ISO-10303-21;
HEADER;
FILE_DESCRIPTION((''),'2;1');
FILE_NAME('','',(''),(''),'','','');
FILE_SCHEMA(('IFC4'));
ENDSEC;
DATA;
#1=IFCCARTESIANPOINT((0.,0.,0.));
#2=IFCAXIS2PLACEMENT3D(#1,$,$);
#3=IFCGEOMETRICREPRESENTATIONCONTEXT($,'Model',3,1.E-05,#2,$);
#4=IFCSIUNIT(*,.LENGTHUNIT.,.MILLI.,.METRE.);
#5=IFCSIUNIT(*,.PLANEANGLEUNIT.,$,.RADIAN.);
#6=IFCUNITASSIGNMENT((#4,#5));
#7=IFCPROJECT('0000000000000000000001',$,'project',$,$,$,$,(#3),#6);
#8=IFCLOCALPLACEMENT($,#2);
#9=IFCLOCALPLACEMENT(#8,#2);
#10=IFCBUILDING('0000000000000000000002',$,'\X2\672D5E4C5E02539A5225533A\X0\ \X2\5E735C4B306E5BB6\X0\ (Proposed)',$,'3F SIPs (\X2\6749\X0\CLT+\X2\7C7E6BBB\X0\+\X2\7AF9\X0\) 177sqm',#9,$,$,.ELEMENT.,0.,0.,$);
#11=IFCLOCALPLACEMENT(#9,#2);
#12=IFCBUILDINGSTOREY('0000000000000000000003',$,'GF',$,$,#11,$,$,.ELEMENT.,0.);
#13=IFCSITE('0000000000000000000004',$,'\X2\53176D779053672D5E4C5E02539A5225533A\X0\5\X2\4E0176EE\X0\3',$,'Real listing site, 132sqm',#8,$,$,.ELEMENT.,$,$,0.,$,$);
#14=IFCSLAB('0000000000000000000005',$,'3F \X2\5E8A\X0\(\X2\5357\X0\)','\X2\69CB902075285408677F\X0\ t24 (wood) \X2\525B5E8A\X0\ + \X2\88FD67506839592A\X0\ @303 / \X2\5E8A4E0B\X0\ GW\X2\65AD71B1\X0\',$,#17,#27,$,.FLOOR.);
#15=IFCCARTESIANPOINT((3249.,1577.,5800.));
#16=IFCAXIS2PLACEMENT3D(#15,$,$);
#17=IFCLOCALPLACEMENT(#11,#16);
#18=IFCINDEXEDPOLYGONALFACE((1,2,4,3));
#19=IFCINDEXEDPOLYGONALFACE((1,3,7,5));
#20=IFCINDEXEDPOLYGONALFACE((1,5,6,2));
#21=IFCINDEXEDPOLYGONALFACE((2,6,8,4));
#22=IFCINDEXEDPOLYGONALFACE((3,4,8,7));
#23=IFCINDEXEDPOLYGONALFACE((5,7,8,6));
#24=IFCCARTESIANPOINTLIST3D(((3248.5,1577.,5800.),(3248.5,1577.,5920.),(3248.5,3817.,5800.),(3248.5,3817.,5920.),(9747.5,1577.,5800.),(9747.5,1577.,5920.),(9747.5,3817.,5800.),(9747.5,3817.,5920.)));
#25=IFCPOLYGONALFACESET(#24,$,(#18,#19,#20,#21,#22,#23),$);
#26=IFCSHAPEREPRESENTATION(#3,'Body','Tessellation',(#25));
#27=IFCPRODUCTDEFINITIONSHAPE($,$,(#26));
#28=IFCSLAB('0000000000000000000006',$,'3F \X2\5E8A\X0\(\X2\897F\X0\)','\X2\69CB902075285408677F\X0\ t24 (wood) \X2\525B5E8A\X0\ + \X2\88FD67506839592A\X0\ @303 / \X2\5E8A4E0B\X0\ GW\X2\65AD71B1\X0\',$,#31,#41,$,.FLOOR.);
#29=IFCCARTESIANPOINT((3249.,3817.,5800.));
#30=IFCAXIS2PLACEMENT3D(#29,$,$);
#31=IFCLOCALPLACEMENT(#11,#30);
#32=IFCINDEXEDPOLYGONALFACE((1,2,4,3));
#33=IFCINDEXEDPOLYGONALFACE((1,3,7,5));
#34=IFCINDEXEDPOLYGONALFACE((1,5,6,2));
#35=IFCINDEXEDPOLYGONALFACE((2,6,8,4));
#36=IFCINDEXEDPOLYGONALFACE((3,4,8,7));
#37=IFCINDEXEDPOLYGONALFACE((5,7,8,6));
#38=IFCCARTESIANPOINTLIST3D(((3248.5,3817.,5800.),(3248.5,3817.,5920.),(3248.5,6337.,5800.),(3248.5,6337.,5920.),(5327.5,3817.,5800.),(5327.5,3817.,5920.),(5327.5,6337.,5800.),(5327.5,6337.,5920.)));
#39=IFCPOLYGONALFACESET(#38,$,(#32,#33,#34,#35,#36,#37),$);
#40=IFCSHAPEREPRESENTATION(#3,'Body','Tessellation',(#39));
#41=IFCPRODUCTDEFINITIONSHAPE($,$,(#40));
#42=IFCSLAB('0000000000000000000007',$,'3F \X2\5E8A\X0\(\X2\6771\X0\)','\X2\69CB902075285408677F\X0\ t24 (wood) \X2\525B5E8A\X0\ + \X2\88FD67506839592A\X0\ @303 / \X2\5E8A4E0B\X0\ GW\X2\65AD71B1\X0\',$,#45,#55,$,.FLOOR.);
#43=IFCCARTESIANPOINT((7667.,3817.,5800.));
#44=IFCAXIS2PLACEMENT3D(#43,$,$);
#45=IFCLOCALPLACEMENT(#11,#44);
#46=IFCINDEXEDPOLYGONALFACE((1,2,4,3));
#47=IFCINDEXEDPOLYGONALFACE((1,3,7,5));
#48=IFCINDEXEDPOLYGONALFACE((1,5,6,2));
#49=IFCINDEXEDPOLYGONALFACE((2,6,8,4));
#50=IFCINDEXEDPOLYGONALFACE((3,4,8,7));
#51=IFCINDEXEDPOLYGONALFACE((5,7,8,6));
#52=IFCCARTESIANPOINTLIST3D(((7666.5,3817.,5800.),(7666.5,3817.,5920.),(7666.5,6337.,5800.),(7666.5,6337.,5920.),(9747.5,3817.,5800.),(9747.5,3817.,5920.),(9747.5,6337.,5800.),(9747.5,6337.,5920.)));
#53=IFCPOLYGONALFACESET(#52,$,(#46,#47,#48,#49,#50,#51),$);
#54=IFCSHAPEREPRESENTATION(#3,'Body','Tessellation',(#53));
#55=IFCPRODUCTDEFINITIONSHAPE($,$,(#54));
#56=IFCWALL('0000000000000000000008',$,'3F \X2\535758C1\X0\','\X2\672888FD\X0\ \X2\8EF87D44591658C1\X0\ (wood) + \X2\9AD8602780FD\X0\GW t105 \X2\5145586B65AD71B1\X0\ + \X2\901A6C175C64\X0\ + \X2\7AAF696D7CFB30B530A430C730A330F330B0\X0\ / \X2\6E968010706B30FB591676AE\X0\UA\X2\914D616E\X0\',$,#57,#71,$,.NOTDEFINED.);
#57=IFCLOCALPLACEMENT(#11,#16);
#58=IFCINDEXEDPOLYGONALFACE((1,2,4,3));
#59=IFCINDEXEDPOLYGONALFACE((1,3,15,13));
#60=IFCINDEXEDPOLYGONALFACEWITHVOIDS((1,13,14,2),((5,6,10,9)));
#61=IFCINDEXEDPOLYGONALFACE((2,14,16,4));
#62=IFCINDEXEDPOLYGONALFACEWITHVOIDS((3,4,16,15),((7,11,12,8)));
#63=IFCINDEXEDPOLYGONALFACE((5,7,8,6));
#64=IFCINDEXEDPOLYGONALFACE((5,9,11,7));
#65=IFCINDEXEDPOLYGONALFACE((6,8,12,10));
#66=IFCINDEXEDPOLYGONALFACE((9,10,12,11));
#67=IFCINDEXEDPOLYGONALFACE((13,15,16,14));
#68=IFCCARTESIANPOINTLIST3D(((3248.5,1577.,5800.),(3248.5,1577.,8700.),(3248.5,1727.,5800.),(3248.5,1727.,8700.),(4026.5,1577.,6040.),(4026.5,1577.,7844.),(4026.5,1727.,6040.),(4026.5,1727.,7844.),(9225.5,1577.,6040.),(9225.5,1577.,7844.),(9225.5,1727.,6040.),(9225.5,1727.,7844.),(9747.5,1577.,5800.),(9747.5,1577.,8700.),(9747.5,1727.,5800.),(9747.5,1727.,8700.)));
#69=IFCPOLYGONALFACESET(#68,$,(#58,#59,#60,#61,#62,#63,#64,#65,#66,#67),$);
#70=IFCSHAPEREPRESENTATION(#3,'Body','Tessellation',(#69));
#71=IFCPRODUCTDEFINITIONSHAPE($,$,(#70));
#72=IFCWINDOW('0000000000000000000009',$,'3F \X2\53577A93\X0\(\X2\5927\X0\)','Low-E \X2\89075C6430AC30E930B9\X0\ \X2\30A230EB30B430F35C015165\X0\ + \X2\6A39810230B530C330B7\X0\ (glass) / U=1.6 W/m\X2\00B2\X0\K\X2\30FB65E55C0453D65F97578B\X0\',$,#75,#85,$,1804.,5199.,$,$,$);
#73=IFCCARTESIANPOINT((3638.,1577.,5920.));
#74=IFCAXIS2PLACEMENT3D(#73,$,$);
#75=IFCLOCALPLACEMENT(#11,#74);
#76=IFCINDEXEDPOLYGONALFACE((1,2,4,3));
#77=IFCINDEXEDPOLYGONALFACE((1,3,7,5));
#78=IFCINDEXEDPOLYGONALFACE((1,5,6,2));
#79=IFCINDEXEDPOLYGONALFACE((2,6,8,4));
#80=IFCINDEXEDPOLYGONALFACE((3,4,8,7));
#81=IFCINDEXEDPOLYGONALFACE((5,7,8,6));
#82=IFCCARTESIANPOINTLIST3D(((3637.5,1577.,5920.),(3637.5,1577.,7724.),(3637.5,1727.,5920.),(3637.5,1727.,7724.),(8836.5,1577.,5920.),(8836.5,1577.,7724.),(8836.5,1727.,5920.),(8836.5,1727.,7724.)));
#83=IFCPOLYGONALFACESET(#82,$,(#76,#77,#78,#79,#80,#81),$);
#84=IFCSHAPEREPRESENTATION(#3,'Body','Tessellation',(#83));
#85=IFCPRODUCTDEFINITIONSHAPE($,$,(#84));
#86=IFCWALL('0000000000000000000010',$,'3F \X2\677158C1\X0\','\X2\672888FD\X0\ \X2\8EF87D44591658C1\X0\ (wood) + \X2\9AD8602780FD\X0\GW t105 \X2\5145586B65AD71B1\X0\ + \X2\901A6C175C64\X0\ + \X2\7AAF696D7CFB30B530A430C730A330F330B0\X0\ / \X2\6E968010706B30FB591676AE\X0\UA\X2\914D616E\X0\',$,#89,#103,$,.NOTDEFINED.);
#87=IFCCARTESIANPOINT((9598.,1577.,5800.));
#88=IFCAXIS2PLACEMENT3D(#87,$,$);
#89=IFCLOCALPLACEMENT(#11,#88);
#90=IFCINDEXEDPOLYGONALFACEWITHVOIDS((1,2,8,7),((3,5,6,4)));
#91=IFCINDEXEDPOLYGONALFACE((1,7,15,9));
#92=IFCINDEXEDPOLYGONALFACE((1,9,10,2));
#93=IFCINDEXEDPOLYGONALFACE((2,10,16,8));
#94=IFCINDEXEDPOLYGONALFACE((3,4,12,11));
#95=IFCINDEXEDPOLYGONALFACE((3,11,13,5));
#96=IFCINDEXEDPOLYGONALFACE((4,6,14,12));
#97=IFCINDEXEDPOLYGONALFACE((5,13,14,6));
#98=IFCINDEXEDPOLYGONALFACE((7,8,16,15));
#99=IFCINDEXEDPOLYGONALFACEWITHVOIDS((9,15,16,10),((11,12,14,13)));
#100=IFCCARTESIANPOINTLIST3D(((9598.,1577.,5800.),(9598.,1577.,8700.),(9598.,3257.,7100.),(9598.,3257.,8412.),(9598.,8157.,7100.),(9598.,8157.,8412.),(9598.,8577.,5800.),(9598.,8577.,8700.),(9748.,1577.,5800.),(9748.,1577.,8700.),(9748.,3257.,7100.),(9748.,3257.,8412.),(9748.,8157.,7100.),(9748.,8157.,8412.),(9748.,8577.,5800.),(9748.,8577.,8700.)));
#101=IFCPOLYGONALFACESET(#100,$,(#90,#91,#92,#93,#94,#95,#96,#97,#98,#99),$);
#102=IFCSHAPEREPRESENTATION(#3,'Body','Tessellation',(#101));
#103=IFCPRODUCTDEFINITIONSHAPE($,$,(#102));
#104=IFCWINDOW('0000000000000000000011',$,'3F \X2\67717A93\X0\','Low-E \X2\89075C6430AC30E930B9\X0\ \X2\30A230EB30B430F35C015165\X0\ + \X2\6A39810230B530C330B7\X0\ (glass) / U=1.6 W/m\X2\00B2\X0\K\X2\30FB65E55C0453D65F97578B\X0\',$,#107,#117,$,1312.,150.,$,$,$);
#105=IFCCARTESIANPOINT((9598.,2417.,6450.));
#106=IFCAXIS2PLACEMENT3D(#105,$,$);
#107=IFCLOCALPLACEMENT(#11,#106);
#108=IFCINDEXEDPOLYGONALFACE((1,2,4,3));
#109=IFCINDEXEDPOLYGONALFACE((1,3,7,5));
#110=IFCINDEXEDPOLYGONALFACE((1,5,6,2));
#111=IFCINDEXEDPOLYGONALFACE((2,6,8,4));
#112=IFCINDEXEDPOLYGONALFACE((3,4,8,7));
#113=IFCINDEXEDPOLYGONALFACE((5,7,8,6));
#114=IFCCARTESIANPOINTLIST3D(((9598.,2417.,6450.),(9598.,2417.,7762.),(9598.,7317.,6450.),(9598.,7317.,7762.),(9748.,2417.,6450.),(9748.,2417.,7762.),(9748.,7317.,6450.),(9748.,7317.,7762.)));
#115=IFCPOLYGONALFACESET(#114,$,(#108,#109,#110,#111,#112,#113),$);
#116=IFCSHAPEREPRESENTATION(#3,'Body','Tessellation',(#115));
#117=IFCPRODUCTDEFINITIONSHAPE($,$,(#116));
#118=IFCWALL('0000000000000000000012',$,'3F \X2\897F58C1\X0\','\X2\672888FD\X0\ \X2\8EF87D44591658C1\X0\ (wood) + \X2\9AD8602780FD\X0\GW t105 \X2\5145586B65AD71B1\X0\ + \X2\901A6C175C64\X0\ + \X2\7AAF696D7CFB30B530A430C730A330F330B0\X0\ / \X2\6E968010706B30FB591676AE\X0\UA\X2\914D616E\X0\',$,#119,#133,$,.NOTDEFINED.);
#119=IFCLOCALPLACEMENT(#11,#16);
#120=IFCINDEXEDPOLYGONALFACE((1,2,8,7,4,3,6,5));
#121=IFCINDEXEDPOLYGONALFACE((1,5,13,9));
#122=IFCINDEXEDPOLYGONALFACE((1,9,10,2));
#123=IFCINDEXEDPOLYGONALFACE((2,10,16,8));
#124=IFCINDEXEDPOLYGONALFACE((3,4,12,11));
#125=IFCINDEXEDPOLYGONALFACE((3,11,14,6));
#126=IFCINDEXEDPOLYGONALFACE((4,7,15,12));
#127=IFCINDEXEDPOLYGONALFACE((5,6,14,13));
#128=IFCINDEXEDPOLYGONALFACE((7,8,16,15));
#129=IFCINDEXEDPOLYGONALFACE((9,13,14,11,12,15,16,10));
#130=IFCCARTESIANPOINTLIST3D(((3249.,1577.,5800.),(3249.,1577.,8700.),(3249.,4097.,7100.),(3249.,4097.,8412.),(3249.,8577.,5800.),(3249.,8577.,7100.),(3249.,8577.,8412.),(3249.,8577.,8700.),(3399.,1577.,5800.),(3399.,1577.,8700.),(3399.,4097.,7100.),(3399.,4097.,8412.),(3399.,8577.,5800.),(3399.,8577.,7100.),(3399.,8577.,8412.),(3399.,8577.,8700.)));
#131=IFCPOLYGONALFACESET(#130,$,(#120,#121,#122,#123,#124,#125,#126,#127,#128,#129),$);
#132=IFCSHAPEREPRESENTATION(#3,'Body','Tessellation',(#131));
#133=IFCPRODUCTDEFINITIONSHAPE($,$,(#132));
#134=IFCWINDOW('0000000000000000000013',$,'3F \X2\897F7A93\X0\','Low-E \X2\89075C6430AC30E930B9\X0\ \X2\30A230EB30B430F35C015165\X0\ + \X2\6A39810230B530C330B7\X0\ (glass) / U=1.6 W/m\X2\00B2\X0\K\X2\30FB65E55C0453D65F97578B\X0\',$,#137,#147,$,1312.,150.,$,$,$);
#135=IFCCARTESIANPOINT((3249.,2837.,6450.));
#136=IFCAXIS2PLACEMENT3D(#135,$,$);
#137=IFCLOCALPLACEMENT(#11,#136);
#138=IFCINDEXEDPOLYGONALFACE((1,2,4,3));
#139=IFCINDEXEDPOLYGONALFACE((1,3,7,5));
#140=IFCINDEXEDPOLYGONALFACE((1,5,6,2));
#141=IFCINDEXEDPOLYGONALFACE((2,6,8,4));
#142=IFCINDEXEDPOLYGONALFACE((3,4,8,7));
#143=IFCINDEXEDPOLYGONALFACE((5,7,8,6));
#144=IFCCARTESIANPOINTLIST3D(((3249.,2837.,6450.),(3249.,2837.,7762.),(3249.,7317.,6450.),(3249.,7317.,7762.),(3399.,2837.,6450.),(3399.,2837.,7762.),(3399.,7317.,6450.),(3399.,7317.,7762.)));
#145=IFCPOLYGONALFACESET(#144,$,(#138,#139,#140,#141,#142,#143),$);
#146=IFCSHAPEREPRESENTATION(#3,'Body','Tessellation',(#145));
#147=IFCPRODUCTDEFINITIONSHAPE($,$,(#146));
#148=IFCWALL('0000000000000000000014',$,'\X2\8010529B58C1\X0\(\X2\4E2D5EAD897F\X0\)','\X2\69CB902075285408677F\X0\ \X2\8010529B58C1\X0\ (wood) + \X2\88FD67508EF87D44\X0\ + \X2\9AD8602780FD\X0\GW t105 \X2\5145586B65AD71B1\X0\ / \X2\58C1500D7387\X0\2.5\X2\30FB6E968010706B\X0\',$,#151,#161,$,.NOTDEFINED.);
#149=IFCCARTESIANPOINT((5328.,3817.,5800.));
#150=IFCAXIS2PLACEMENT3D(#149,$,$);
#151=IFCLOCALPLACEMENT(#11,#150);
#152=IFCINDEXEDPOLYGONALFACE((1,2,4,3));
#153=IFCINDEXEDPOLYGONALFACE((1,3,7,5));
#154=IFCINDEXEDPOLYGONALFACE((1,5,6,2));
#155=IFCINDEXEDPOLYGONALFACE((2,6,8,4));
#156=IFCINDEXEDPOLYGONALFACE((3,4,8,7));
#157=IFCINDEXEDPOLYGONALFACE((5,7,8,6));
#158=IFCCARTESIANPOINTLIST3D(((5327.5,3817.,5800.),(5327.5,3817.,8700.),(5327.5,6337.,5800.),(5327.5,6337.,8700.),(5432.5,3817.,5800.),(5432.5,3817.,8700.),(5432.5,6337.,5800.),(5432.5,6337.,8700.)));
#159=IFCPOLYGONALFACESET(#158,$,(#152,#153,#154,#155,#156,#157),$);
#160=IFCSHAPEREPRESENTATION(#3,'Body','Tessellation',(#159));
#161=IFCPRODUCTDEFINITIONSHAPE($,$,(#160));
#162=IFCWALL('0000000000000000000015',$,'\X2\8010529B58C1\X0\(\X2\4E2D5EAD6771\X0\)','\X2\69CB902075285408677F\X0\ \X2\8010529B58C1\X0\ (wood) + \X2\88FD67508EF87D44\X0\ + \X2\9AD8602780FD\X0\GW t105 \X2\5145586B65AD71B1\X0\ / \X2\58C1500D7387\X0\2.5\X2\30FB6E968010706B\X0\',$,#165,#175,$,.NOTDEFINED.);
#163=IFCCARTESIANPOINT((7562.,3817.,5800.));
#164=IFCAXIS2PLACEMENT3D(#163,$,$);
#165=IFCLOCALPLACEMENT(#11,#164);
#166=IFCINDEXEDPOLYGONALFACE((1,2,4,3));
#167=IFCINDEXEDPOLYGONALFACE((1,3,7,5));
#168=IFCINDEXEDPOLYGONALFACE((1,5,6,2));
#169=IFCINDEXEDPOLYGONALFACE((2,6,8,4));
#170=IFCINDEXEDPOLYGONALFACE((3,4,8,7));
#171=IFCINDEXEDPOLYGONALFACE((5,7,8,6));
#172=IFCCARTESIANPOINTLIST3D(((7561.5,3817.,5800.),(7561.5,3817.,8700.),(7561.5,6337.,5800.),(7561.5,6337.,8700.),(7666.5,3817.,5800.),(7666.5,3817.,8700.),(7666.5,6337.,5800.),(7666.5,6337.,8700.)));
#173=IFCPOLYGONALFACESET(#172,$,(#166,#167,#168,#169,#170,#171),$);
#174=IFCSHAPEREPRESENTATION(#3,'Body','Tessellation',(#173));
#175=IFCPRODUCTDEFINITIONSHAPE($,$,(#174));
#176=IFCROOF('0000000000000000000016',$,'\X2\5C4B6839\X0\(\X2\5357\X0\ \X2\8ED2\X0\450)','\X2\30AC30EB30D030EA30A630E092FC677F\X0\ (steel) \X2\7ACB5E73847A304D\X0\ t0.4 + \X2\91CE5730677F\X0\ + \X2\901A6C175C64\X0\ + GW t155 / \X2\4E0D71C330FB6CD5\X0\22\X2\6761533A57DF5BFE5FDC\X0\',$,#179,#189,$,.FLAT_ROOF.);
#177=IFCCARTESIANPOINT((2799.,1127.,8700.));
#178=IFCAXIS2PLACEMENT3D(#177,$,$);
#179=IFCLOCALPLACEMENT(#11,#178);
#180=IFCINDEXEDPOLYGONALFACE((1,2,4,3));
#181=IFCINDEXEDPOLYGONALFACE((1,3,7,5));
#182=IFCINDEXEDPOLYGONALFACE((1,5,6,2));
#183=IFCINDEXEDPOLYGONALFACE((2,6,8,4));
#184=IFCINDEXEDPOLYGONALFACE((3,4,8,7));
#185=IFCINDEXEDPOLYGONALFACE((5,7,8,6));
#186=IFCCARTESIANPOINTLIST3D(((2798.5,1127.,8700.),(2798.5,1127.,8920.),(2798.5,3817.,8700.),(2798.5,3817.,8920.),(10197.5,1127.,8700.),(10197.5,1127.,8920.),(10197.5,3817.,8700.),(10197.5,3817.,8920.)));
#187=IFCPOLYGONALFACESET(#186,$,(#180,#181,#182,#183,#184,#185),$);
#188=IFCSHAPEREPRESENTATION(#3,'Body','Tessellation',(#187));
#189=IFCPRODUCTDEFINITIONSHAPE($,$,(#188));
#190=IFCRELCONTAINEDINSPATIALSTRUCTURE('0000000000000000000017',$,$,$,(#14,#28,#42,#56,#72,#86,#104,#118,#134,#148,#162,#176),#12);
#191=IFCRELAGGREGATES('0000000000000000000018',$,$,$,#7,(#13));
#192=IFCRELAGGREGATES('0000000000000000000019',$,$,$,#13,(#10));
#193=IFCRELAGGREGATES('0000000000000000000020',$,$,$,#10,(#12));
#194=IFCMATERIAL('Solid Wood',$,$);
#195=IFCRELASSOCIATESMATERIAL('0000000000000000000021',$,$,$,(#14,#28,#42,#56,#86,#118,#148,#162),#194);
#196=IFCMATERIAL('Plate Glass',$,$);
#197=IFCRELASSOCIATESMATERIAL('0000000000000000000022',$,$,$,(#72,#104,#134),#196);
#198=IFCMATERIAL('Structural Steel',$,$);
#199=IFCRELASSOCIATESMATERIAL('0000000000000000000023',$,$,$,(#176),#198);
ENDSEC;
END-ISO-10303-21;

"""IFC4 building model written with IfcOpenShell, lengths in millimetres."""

from ifc_helpers import new_model, si_unit, frame, frame_2d, origin, place, context, project, spatial, rectangle, extrude, material, element, fill, save


model = new_model("IFC4")

# Units and contexts
model_context = context("Model", 3, precision=1e-05, world=origin())
ifc_project = project(units=[si_unit("LENGTHUNIT", "METRE", prefix="MILLI"), si_unit("PLANEANGLEUNIT", "RADIAN")], contexts=[model_context])

# Site, building, storey
site_placement = place(None, origin())
site = spatial("IfcSite", under=ifc_project, at=site_placement, Name="北海道札幌市厚別区5丁目3", ObjectType="Real listing site, 132sqm", CompositionType="ELEMENT", RefElevation=0.0)
building_placement = place(site_placement, origin())
building = spatial("IfcBuilding", under=site, at=building_placement, Name="札幌市厚別区 平屋の家 (Proposed)", ObjectType="3F SIPs (杉CLT+籾殻+竹) 177sqm", CompositionType="ELEMENT", ElevationOfRefHeight=0.0, ElevationOfTerrain=0.0)
storey_placement = place(building_placement, origin())
storey = spatial("IfcBuildingStorey", under=building, at=storey_placement, Name="GF", CompositionType="ELEMENT", Elevation=0.0)

# Slabs
ifc_material_1 = material(Name="Solid Wood")
slab_1_placement = place(storey_placement, frame((3249.0, 1577.0, 5800.0)))
element("IfcSlab", 1, at=slab_1_placement, inside=storey, material=ifc_material_1, Name="3F 床(南)", Description="構造用合板 t24 (wood) 剛床 + 製材根太 @303 / 床下 GW断熱", PredefinedType="FLOOR", context=model_context, shape_type="SweptSolid", body=[
    extrude(rectangle(XDim=6499.0, YDim=2240.0, at=frame_2d((3249.0, 1120.0))), frame((3249.0, 1577.0, 5800.0)), (0.0, 0.0, 1.0), 120.0),
])
slab_2_placement = place(storey_placement, frame((3249.0, 3817.0, 5800.0)))
element("IfcSlab", 2, at=slab_2_placement, inside=storey, material=ifc_material_1, Name="3F 床(西)", Description="構造用合板 t24 (wood) 剛床 + 製材根太 @303 / 床下 GW断熱", PredefinedType="FLOOR", context=model_context, shape_type="SweptSolid", body=[
    extrude(rectangle(XDim=2079.0, YDim=2520.0, at=frame_2d((1039.0, 1260.0))), frame((3249.0, 3817.0, 5800.0)), (0.0, 0.0, 1.0), 120.0),
])
slab_3_placement = place(storey_placement, frame((7667.0, 3817.0, 5800.0)))
element("IfcSlab", 3, at=slab_3_placement, inside=storey, material=ifc_material_1, Name="3F 床(東)", Description="構造用合板 t24 (wood) 剛床 + 製材根太 @303 / 床下 GW断熱", PredefinedType="FLOOR", context=model_context, shape_type="SweptSolid", body=[
    extrude(rectangle(XDim=2081.0, YDim=2520.0, at=frame_2d((1040.0, 1260.0))), frame((7667.0, 3817.0, 5800.0)), (0.0, 0.0, 1.0), 120.0),
])

# Walls, openings, windows
wall_1_placement = place(storey_placement, frame((3249.0, 1577.0, 5800.0)))
wall_1 = element("IfcWall", 4, at=wall_1_placement, inside=storey, material=ifc_material_1, Name="3F 南壁", Description="木製 軸組外壁 (wood) + 高性能GW t105 充填断熱 + 通気層 + 窯業系サイディング / 準耐火・外皮UA配慮", PredefinedType="NOTDEFINED", context=model_context, shape_type="SweptSolid", body=[
    extrude(rectangle(XDim=6499.0, YDim=150.0, at=frame_2d((3249.0, 75.0))), frame((3249.0, 1577.0, 5800.0)), (0.0, 0.0, 1.0), 2900.0),
])
opening_1_placement = place(storey_placement, frame((3638.0, 1577.0, 5920.0)))
opening_1 = element("IfcOpeningElement", 5, at=opening_1_placement, cuts=wall_1, PredefinedType="NOTDEFINED", context=model_context, shape_type="SweptSolid", body=[
    extrude(rectangle(XDim=5199.0, YDim=150.0, at=frame_2d((2599.0, 75.0))), frame((3638.0, 1577.0, 5920.0)), (0.0, 0.0, 1.0), 1804.0),
])
ifc_material_2 = material(Name="Plate Glass")
window_1_placement = place(storey_placement, frame((3638.0, 1577.0, 5920.0)))
window_1 = element("IfcWindow", 6, at=window_1_placement, inside=storey, material=ifc_material_2, Name="3F 南窓(大)", Description="Low-E 複層ガラス アルゴン封入 + 樹脂サッシ (glass) / U=1.6 W/m²K・日射取得型", OverallHeight=1804.0, OverallWidth=5199.0, context=model_context, shape_type="SweptSolid", body=[
    extrude(rectangle(XDim=5199.0, YDim=150.0, at=frame_2d((2599.0, 75.0))), frame((3638.0, 1577.0, 5920.0)), (0.0, 0.0, 1.0), 1804.0),
])
fill(opening_1, window_1)
wall_2_placement = place(storey_placement, frame((9598.0, 1577.0, 5800.0)))
wall_2 = element("IfcWall", 7, at=wall_2_placement, inside=storey, material=ifc_material_1, Name="3F 東壁", Description="木製 軸組外壁 (wood) + 高性能GW t105 充填断熱 + 通気層 + 窯業系サイディング / 準耐火・外皮UA配慮", PredefinedType="NOTDEFINED", context=model_context, shape_type="SweptSolid", body=[
    extrude(rectangle(XDim=150.0, YDim=7000.0, at=frame_2d((75.0, 3500.0))), frame((9598.0, 1577.0, 5800.0)), (0.0, 0.0, 1.0), 2900.0),
])
opening_2_placement = place(storey_placement, frame((9598.0, 2417.0, 6450.0)))
opening_2 = element("IfcOpeningElement", 8, at=opening_2_placement, cuts=wall_2, PredefinedType="NOTDEFINED", context=model_context, shape_type="SweptSolid", body=[
    extrude(rectangle(XDim=150.0, YDim=4900.0, at=frame_2d((75.0, 2450.0))), frame((9598.0, 2417.0, 6450.0)), (0.0, 0.0, 1.0), 1312.0),
])
window_2_placement = place(storey_placement, frame((9598.0, 2417.0, 6450.0)))
window_2 = element("IfcWindow", 9, at=window_2_placement, inside=storey, material=ifc_material_2, Name="3F 東窓", Description="Low-E 複層ガラス アルゴン封入 + 樹脂サッシ (glass) / U=1.6 W/m²K・日射取得型", OverallHeight=1312.0, OverallWidth=150.0, context=model_context, shape_type="SweptSolid", body=[
    extrude(rectangle(XDim=150.0, YDim=4900.0, at=frame_2d((75.0, 2450.0))), frame((9598.0, 2417.0, 6450.0)), (0.0, 0.0, 1.0), 1312.0),
])
fill(opening_2, window_2)
wall_3_placement = place(storey_placement, frame((3249.0, 1577.0, 5800.0)))
wall_3 = element("IfcWall", 10, at=wall_3_placement, inside=storey, material=ifc_material_1, Name="3F 西壁", Description="木製 軸組外壁 (wood) + 高性能GW t105 充填断熱 + 通気層 + 窯業系サイディング / 準耐火・外皮UA配慮", PredefinedType="NOTDEFINED", context=model_context, shape_type="SweptSolid", body=[
    extrude(rectangle(XDim=150.0, YDim=7000.0, at=frame_2d((75.0, 3500.0))), frame((3249.0, 1577.0, 5800.0)), (0.0, 0.0, 1.0), 2900.0),
])
opening_3_placement = place(storey_placement, frame((3249.0, 2837.0, 6450.0)))
opening_3 = element("IfcOpeningElement", 11, at=opening_3_placement, cuts=wall_3, PredefinedType="NOTDEFINED", context=model_context, shape_type="SweptSolid", body=[
    extrude(rectangle(XDim=150.0, YDim=4480.0, at=frame_2d((75.0, 2240.0))), frame((3249.0, 2837.0, 6450.0)), (0.0, 0.0, 1.0), 1312.0),
])
window_3_placement = place(storey_placement, frame((3249.0, 2837.0, 6450.0)))
window_3 = element("IfcWindow", 12, at=window_3_placement, inside=storey, material=ifc_material_2, Name="3F 西窓", Description="Low-E 複層ガラス アルゴン封入 + 樹脂サッシ (glass) / U=1.6 W/m²K・日射取得型", OverallHeight=1312.0, OverallWidth=150.0, context=model_context, shape_type="SweptSolid", body=[
    extrude(rectangle(XDim=150.0, YDim=4480.0, at=frame_2d((75.0, 2240.0))), frame((3249.0, 2837.0, 6450.0)), (0.0, 0.0, 1.0), 1312.0),
])
fill(opening_3, window_3)

# Walls
wall_4_placement = place(storey_placement, frame((5328.0, 3817.0, 5800.0)))
element("IfcWall", 13, at=wall_4_placement, inside=storey, material=ifc_material_1, Name="耐力壁(中庭西)", Description="構造用合板 耐力壁 (wood) + 製材軸組 + 高性能GW t105 充填断熱 / 壁倍率2.5・準耐火", PredefinedType="NOTDEFINED", context=model_context, shape_type="SweptSolid", body=[
    extrude(rectangle(XDim=105.0, YDim=2520.0, at=frame_2d((52.0, 1260.0))), frame((5328.0, 3817.0, 5800.0)), (0.0, 0.0, 1.0), 2900.0),
])
wall_5_placement = place(storey_placement, frame((7562.0, 3817.0, 5800.0)))
element("IfcWall", 14, at=wall_5_placement, inside=storey, material=ifc_material_1, Name="耐力壁(中庭東)", Description="構造用合板 耐力壁 (wood) + 製材軸組 + 高性能GW t105 充填断熱 / 壁倍率2.5・準耐火", PredefinedType="NOTDEFINED", context=model_context, shape_type="SweptSolid", body=[
    extrude(rectangle(XDim=105.0, YDim=2520.0, at=frame_2d((52.0, 1260.0))), frame((7562.0, 3817.0, 5800.0)), (0.0, 0.0, 1.0), 2900.0),
])

# Roof
ifc_material_3 = material(Name="Structural Steel")
roof_1_placement = place(storey_placement, frame((2799.0, 1127.0, 8700.0)))
element("IfcRoof", 15, at=roof_1_placement, inside=storey, material=ifc_material_3, Name="屋根(南 軒450)", Description="ガルバリウム鋼板 (steel) 立平葺き t0.4 + 野地板 + 通気層 + GW t155 / 不燃・法22条区域対応", PredefinedType="FLAT_ROOF", context=model_context, shape_type="SweptSolid", body=[
    extrude(rectangle(XDim=7399.0, YDim=2690.0, at=frame_2d((3699.0, 1345.0))), frame((2799.0, 1127.0, 8700.0)), (0.0, 0.0, 1.0), 220.0),
])

save(model, "model.ifc")
